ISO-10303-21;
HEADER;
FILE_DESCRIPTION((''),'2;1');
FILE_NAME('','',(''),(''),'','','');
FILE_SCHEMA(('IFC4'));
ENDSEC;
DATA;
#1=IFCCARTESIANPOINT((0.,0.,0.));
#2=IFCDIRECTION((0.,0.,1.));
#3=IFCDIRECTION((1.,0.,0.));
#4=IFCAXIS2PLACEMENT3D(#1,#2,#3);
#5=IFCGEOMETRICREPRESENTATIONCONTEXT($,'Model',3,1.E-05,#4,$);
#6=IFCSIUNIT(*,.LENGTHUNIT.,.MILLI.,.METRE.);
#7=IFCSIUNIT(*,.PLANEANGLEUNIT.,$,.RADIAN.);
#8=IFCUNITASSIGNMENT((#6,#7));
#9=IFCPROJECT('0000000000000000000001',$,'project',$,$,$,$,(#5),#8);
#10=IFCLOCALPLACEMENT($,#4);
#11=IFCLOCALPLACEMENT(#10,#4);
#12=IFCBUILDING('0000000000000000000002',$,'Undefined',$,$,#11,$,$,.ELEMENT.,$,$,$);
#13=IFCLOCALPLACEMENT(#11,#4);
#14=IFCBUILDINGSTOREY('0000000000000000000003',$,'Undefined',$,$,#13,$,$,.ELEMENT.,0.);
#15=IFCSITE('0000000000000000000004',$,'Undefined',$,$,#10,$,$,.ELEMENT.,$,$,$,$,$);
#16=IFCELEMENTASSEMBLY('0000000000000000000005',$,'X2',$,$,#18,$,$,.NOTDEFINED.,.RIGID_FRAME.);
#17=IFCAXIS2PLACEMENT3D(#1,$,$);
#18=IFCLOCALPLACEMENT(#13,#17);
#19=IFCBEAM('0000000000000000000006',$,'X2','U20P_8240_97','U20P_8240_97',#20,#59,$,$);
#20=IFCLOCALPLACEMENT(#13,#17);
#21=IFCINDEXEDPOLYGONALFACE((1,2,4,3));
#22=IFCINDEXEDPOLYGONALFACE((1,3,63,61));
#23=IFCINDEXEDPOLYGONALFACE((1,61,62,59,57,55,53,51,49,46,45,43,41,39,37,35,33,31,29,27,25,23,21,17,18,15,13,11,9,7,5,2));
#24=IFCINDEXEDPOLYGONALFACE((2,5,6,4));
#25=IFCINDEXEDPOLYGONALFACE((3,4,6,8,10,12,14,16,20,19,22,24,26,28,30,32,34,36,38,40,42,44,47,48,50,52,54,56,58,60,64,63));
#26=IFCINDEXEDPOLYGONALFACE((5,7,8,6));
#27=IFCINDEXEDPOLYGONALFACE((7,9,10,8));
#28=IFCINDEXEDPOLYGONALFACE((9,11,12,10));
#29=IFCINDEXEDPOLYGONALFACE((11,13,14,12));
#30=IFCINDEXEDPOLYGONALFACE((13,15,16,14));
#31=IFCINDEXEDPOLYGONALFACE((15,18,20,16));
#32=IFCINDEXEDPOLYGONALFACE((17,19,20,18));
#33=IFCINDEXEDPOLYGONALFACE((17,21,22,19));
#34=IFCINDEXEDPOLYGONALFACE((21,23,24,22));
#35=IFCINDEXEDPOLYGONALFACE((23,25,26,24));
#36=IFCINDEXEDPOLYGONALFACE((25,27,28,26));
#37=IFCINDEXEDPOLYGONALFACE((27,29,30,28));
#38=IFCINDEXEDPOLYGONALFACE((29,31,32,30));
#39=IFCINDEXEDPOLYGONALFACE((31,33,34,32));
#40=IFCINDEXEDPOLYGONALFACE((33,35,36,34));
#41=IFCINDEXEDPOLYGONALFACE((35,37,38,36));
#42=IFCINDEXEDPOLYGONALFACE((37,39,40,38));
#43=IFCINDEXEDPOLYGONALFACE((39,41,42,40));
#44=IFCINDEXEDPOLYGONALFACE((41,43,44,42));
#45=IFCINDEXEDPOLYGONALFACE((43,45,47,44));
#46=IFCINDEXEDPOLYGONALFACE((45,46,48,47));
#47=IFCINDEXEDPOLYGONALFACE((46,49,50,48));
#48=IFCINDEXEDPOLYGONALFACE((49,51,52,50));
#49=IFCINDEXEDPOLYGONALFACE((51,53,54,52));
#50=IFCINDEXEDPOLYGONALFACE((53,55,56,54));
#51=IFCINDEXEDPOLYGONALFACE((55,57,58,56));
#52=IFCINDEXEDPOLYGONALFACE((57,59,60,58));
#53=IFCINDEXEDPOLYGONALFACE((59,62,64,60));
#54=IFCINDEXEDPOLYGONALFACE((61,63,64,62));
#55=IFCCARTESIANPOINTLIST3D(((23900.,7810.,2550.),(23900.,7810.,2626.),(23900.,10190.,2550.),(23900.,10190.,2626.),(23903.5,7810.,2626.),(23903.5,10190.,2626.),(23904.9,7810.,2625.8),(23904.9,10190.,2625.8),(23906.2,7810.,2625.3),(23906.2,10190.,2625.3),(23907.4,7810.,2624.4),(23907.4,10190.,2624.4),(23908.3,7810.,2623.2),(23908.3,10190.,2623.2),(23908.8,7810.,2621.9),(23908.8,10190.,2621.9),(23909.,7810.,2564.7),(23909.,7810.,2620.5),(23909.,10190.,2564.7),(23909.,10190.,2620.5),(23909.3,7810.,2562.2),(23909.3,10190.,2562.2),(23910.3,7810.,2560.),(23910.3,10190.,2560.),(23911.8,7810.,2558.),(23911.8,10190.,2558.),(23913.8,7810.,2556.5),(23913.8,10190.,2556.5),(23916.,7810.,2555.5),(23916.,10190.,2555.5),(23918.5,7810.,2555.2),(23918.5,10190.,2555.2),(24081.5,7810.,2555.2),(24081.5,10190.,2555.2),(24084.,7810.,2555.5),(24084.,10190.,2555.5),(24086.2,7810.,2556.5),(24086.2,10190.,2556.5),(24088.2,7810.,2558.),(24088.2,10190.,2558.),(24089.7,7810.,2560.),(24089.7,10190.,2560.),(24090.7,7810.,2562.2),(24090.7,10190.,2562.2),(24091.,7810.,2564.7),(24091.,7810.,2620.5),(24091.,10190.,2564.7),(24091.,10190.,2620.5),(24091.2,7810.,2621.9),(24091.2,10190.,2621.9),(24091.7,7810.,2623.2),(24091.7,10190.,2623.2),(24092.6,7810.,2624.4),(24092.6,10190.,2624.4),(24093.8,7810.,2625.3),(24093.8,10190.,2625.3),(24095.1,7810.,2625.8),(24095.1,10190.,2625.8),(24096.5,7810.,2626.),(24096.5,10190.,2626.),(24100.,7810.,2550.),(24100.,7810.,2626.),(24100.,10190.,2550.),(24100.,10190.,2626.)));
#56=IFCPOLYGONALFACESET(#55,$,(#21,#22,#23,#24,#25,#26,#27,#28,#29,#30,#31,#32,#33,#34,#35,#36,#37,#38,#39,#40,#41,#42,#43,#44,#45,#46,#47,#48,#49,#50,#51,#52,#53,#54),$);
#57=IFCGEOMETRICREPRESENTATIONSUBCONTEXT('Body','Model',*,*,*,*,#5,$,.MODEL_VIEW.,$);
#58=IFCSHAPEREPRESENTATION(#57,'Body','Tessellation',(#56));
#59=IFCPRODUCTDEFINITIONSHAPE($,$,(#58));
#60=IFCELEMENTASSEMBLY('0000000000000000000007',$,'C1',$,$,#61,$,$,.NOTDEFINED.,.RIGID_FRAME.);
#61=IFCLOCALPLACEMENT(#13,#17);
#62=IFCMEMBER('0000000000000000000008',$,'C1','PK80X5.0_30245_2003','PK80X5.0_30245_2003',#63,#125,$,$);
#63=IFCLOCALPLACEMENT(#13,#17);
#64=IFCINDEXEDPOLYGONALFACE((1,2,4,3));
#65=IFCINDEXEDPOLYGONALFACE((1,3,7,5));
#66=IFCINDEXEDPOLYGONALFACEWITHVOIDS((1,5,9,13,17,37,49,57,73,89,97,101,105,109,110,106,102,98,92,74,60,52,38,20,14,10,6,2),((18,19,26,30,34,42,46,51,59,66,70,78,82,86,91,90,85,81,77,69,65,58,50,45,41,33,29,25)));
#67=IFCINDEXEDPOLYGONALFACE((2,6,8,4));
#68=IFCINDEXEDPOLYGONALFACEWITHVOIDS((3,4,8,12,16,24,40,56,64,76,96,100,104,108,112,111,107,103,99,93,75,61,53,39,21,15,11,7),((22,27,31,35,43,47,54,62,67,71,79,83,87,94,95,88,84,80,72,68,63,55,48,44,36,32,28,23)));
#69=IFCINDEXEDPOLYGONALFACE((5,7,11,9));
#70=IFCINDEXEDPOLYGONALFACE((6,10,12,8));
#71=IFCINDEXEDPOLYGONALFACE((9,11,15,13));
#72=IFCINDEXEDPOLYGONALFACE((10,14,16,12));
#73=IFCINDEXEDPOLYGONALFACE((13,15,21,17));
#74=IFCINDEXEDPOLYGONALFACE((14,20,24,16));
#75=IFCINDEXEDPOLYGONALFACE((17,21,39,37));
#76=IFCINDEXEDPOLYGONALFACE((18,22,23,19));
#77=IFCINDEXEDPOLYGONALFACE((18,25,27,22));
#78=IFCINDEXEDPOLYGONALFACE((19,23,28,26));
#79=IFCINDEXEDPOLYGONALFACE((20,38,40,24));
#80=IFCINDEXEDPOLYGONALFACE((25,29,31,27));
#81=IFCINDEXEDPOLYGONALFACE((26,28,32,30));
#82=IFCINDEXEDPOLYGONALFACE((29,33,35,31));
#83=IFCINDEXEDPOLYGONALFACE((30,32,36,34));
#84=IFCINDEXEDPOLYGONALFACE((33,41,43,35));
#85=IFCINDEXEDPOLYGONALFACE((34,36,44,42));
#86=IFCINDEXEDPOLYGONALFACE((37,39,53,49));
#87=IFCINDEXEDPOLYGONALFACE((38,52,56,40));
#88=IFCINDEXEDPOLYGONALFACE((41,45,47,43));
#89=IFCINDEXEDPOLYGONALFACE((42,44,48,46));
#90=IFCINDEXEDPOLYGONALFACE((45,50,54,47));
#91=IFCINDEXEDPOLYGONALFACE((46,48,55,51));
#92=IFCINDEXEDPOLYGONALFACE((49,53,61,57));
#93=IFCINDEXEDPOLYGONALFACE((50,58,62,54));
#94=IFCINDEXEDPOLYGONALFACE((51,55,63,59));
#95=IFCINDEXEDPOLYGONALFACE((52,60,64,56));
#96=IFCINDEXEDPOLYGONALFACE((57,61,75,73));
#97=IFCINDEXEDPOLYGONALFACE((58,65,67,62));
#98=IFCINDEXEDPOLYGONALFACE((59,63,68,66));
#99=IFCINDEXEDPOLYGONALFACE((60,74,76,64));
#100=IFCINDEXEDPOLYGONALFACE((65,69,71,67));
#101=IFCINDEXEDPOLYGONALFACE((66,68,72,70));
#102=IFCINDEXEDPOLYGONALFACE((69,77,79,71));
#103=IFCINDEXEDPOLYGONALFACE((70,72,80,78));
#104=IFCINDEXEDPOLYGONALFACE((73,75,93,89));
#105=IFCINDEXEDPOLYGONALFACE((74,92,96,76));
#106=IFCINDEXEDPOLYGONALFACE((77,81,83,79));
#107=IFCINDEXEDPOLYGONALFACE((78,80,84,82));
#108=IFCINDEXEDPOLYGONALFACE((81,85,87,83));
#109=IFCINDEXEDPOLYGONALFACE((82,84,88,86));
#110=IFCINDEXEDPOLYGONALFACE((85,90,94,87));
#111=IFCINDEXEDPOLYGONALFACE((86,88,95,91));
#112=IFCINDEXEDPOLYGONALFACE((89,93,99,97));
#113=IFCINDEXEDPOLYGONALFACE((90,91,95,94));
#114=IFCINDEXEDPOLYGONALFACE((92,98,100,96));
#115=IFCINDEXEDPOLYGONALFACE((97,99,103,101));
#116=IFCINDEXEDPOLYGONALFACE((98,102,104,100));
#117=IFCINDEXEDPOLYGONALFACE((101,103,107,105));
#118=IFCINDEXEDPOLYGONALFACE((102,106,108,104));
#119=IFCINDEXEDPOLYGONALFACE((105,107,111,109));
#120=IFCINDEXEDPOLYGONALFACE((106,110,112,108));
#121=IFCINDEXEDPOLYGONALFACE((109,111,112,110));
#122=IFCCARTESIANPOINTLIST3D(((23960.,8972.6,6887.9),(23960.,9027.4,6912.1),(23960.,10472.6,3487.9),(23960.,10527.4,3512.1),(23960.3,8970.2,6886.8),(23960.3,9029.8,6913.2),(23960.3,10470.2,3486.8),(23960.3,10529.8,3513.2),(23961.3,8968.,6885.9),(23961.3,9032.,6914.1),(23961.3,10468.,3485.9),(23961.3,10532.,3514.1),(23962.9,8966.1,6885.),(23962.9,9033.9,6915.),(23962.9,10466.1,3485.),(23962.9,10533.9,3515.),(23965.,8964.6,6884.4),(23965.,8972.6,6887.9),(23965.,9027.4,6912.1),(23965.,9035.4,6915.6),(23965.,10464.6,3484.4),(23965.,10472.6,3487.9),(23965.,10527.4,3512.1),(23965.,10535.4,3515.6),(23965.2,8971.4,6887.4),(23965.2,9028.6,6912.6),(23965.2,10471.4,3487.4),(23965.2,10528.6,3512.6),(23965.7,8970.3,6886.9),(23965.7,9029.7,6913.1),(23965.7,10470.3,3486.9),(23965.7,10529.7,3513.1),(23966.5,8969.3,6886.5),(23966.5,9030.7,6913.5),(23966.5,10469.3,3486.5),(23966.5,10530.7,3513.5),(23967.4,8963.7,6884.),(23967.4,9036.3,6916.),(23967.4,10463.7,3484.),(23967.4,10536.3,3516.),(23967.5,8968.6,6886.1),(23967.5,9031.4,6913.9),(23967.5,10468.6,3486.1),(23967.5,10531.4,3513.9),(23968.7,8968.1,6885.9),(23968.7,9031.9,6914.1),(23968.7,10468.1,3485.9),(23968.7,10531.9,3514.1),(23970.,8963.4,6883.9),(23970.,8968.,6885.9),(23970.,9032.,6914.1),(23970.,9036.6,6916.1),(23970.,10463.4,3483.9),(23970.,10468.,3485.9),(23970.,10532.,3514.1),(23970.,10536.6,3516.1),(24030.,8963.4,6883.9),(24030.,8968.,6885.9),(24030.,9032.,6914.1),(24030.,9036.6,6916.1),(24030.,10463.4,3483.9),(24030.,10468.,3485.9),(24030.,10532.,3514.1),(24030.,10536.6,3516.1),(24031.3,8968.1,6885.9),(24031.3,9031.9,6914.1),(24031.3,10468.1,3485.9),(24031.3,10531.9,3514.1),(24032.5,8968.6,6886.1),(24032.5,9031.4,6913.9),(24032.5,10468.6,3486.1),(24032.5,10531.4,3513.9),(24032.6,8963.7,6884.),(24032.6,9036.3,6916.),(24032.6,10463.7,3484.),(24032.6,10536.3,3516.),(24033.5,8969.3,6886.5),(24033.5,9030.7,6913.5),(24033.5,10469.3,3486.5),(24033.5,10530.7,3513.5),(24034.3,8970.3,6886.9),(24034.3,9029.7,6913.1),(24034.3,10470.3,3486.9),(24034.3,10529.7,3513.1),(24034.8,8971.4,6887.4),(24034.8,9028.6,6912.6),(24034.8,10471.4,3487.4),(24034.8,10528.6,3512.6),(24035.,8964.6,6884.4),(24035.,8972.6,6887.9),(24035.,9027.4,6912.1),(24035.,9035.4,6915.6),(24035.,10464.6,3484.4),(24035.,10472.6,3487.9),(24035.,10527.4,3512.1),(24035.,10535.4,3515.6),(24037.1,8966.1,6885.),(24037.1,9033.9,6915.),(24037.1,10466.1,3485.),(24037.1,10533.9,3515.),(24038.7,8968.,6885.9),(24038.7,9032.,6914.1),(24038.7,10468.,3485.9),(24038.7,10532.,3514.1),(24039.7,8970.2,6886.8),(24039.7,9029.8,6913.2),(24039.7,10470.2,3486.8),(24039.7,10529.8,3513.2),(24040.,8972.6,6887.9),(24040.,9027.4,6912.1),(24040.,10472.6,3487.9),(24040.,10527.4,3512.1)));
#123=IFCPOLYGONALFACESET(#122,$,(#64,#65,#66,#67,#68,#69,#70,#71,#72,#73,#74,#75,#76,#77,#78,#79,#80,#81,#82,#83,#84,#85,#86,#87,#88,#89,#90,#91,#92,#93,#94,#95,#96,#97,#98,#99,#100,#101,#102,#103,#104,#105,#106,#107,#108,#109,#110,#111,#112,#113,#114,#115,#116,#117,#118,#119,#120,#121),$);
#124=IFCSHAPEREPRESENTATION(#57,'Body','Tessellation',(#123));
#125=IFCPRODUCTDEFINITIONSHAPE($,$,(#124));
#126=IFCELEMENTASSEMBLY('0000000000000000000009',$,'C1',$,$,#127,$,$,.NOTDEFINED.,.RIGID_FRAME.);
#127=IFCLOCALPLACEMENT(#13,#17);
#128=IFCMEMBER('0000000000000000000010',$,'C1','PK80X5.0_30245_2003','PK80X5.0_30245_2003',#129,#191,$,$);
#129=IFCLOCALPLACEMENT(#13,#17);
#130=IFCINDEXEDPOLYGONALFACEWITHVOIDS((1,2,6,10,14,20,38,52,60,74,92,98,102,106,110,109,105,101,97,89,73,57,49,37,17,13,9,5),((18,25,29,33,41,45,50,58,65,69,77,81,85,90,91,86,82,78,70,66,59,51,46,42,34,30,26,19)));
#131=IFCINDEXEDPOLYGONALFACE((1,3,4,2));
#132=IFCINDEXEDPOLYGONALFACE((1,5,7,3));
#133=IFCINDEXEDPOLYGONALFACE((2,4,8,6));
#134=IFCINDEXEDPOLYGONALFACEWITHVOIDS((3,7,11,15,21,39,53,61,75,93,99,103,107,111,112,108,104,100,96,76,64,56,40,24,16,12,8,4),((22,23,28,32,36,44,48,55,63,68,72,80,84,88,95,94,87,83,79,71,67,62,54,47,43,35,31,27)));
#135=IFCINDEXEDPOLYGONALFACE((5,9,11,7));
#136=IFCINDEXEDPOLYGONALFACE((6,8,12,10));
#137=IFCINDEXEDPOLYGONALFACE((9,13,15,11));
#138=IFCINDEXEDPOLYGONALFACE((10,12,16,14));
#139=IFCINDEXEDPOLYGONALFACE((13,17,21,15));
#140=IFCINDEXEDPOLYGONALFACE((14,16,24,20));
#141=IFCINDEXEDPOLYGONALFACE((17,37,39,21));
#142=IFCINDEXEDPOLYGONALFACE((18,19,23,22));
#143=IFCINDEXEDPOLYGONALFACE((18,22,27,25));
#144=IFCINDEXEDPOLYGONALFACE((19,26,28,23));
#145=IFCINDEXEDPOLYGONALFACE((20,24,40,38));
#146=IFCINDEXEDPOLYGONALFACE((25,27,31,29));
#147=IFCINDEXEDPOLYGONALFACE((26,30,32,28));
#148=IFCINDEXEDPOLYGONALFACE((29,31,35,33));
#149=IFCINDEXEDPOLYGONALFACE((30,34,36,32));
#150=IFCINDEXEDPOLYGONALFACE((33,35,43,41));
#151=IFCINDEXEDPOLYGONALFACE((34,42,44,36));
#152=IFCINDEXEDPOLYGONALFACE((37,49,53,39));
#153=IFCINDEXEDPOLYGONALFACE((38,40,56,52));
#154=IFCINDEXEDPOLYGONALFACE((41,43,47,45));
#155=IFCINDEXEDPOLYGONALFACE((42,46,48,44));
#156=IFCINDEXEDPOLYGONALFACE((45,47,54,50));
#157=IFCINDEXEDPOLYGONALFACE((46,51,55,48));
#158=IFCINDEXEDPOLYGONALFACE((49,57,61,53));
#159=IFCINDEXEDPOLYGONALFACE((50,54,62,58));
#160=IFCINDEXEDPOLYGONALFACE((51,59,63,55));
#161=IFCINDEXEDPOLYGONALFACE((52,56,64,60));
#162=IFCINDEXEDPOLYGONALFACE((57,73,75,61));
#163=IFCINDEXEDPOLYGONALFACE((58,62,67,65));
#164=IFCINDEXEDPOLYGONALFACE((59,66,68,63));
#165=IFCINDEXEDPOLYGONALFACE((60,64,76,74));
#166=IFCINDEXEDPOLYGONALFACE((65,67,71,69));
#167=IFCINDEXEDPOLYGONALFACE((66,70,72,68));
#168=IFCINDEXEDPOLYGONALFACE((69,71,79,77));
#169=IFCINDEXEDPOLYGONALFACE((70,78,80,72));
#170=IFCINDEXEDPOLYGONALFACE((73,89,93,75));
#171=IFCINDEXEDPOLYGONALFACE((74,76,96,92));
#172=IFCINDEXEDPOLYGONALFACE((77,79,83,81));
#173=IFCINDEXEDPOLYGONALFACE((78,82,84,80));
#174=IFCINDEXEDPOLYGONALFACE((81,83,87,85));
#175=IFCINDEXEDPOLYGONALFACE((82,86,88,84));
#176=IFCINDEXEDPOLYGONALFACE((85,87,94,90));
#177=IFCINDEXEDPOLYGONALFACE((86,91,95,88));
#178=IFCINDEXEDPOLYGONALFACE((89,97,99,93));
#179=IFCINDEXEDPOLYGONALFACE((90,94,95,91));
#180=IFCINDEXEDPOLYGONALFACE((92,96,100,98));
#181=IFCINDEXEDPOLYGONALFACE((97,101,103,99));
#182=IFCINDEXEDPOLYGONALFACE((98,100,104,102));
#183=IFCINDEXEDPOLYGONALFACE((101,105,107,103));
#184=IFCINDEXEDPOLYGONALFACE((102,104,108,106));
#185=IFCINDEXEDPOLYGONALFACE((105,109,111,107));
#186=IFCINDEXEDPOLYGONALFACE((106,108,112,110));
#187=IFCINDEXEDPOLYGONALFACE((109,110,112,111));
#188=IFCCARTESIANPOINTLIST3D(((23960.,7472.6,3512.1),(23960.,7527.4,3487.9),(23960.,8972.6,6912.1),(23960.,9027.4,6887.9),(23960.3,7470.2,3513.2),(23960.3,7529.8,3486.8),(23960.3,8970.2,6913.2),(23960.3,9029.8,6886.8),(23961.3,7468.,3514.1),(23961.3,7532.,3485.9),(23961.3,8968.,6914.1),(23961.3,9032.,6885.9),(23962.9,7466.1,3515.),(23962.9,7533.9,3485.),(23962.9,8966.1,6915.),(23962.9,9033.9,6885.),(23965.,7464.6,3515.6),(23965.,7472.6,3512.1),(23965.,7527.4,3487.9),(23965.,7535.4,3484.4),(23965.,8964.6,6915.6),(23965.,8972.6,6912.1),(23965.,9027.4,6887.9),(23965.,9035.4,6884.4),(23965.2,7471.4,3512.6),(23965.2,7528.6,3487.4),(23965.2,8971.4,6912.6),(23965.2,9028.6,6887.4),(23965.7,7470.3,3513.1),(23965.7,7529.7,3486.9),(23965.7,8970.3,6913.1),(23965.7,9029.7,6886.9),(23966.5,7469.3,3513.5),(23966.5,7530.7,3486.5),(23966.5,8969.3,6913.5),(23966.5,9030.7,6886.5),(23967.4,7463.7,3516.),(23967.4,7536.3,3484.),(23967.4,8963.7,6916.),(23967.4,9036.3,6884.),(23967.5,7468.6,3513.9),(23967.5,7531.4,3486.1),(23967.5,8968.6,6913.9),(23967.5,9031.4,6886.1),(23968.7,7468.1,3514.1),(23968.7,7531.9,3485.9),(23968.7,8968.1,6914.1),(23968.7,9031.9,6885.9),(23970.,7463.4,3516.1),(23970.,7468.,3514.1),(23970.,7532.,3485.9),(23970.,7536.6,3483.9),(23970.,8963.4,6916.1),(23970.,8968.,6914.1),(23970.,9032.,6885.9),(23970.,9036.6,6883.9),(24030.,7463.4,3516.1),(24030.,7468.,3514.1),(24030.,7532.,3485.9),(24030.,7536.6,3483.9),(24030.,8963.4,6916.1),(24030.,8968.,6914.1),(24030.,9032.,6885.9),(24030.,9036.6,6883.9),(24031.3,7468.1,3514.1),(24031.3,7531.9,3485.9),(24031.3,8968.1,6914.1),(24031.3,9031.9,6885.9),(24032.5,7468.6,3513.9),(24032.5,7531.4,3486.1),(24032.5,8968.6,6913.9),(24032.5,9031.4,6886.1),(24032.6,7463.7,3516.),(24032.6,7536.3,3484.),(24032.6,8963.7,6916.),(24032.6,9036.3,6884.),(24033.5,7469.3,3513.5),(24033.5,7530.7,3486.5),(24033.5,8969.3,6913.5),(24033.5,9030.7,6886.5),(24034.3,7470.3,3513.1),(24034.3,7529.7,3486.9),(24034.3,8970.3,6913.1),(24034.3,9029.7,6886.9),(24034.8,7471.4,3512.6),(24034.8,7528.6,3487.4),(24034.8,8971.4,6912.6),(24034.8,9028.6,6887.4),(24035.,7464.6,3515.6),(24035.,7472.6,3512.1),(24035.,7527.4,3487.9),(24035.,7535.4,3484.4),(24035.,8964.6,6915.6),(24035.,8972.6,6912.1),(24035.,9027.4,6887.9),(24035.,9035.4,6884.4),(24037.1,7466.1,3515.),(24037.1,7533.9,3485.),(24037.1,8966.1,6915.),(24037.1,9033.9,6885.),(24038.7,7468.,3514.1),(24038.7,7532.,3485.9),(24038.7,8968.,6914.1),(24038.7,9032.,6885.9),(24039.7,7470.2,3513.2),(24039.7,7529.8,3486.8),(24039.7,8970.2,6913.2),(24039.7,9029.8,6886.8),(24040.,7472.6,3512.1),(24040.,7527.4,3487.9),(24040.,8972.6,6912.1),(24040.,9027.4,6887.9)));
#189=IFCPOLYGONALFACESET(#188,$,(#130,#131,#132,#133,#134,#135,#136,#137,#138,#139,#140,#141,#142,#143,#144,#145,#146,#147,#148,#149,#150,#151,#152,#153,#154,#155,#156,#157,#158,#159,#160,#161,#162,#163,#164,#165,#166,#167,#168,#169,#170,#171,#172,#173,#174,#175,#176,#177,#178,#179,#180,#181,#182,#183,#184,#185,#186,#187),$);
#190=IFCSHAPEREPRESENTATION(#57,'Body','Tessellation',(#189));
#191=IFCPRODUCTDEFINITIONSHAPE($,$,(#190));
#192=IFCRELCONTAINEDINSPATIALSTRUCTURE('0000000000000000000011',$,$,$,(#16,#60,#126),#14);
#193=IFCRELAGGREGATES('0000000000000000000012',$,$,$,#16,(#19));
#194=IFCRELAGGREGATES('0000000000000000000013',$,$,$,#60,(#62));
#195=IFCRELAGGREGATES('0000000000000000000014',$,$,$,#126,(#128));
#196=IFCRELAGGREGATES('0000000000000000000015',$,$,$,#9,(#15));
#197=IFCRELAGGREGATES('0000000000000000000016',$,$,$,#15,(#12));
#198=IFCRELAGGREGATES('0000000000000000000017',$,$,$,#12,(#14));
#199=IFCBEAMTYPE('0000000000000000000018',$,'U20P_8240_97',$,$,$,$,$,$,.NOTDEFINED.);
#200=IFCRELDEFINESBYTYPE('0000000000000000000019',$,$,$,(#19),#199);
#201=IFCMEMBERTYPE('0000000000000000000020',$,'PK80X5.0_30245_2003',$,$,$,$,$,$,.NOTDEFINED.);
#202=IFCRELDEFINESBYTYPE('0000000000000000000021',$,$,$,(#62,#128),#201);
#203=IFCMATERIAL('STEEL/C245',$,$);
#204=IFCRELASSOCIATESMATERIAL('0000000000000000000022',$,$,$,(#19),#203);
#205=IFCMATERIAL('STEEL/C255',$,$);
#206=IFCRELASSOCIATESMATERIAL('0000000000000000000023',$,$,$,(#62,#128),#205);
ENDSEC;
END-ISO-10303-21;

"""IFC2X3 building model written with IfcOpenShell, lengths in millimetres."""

from ifc_helpers import new_model, si_unit, frame, origin_with_axes, origin_2d_with_axis, place, context, subcontext, project, spatial, hollow_rectangle, u_section, extrude, material, type_object, element, aggregate, save


model = new_model("IFC2X3")

# Units and contexts
model_context = context("Model", 3, precision=1e-05, world=origin_with_axes())
body_context = subcontext(model_context, "Body", "Model", "MODEL_VIEW")
ifc_project = project(units=[si_unit("LENGTHUNIT", "METRE", prefix="MILLI"), si_unit("PLANEANGLEUNIT", "RADIAN")], contexts=[model_context])

# Site, building, storey
site_placement = place(None, origin_with_axes())
site = spatial("IfcSite", under=ifc_project, at=site_placement, Name="Undefined", CompositionType="ELEMENT")
building_placement = place(site_placement, origin_with_axes())
building = spatial("IfcBuilding", under=site, at=building_placement, Name="Undefined", CompositionType="ELEMENT")
storey_placement = place(building_placement, origin_with_axes())
storey = spatial("IfcBuildingStorey", under=building, at=storey_placement, Name="Undefined", CompositionType="ELEMENT", Elevation=0.0)

# Shared definitions
ifc_material_1 = material(Name="STEEL/C245")

# Element assembly, beam
ifc_material_2 = material(Name="STEEL/C255")
beam_type_1 = type_object("IfcBeamType", Name="U20P_8240_97", PredefinedType="NOTDEFINED")
assembly_1_placement = place(storey_placement, origin_with_axes())
assembly_1 = element("IfcElementAssembly", 1, at=assembly_1_placement, inside=storey, Name="X2", AssemblyPlace="NOTDEFINED", PredefinedType="RIGID_FRAME")
beam_1_placement = place(assembly_1_placement, frame((24000.0, 7810.0, 2588.0), z_axis=(-1.0, 0.0, 0.0), x_axis=(0.0, 1.0, 0.0)))
beam_1 = element("IfcBeam", 2, at=beam_1_placement, type_object=beam_type_1, material=ifc_material_1, Name="X2", Description="U20P_8240_97", ObjectType="U20P_8240_97", context=body_context, shape_type="SweptSolid", body=[
    extrude(u_section(Depth=200.0, FlangeWidth=76.0, WebThickness=5.2, FlangeThickness=9.0, FilletRadius=9.5, EdgeRadius=5.5, at=origin_2d_with_axis()), frame((2380.0, 0.0, 0.0), z_axis=(-1.0, 0.0, 0.0), x_axis=(0.0, -1.0, 0.0)), (0.0, 0.0, 1.0), 2380.0),
])
aggregate(assembly_1, [beam_1])

# Element assemblies, members
assembly_2_placement = place(storey_placement, origin_with_axes())
assembly_2 = element("IfcElementAssembly", 3, at=assembly_2_placement, inside=storey, Name="C1", AssemblyPlace="NOTDEFINED", PredefinedType="RIGID_FRAME")
member_type = type_object("IfcMemberType", Name="PK80X5.0_30245_2003", PredefinedType="NOTDEFINED")
member_1_placement = place(assembly_2_placement, frame((24000.0, 10500.0, 3500.0), z_axis=(0.0, -0.914918, -0.40364), x_axis=(0.0, -0.40364, 0.914918)))
member_1 = element("IfcMember", 4, at=member_1_placement, type_object=member_type, material=ifc_material_2, Name="C1", Description="PK80X5.0_30245_2003", ObjectType="PK80X5.0_30245_2003", context=body_context, shape_type="SweptSolid", body=[
    extrude(hollow_rectangle(XDim=80.0, YDim=80.0, WallThickness=5.0, InnerFilletRadius=5.0, OuterFilletRadius=10.0, at=origin_2d_with_axis()), frame((3716.2, 0.0, 0.0), z_axis=(-1.0, 0.0, 0.0), x_axis=(0.0, -1.0, 0.0)), (0.0, 0.0, 1.0), 3716.2),
])
aggregate(assembly_2, [member_1])
assembly_3_placement = place(storey_placement, origin_with_axes())
assembly_3 = element("IfcElementAssembly", 5, at=assembly_3_placement, inside=storey, Name="C1", AssemblyPlace="NOTDEFINED", PredefinedType="RIGID_FRAME")
member_2_placement = place(assembly_3_placement, frame((24000.0, 7500.0, 3500.0), z_axis=(0.0, 0.914918, -0.40364), x_axis=(0.0, 0.40364, 0.914918)))
member_2 = element("IfcMember", 6, at=member_2_placement, type_object=member_type, material=ifc_material_2, Name="C1", Description="PK80X5.0_30245_2003", ObjectType="PK80X5.0_30245_2003", context=body_context, shape_type="SweptSolid", body=[
    extrude(hollow_rectangle(XDim=80.0, YDim=80.0, WallThickness=5.0, InnerFilletRadius=5.0, OuterFilletRadius=10.0, at=origin_2d_with_axis()), frame((3716.2, 0.0, 0.0), z_axis=(-1.0, 0.0, 0.0), x_axis=(0.0, -1.0, 0.0)), (0.0, 0.0, 1.0), 3716.2),
])
aggregate(assembly_3, [member_2])

save(model, "model.ifc")
